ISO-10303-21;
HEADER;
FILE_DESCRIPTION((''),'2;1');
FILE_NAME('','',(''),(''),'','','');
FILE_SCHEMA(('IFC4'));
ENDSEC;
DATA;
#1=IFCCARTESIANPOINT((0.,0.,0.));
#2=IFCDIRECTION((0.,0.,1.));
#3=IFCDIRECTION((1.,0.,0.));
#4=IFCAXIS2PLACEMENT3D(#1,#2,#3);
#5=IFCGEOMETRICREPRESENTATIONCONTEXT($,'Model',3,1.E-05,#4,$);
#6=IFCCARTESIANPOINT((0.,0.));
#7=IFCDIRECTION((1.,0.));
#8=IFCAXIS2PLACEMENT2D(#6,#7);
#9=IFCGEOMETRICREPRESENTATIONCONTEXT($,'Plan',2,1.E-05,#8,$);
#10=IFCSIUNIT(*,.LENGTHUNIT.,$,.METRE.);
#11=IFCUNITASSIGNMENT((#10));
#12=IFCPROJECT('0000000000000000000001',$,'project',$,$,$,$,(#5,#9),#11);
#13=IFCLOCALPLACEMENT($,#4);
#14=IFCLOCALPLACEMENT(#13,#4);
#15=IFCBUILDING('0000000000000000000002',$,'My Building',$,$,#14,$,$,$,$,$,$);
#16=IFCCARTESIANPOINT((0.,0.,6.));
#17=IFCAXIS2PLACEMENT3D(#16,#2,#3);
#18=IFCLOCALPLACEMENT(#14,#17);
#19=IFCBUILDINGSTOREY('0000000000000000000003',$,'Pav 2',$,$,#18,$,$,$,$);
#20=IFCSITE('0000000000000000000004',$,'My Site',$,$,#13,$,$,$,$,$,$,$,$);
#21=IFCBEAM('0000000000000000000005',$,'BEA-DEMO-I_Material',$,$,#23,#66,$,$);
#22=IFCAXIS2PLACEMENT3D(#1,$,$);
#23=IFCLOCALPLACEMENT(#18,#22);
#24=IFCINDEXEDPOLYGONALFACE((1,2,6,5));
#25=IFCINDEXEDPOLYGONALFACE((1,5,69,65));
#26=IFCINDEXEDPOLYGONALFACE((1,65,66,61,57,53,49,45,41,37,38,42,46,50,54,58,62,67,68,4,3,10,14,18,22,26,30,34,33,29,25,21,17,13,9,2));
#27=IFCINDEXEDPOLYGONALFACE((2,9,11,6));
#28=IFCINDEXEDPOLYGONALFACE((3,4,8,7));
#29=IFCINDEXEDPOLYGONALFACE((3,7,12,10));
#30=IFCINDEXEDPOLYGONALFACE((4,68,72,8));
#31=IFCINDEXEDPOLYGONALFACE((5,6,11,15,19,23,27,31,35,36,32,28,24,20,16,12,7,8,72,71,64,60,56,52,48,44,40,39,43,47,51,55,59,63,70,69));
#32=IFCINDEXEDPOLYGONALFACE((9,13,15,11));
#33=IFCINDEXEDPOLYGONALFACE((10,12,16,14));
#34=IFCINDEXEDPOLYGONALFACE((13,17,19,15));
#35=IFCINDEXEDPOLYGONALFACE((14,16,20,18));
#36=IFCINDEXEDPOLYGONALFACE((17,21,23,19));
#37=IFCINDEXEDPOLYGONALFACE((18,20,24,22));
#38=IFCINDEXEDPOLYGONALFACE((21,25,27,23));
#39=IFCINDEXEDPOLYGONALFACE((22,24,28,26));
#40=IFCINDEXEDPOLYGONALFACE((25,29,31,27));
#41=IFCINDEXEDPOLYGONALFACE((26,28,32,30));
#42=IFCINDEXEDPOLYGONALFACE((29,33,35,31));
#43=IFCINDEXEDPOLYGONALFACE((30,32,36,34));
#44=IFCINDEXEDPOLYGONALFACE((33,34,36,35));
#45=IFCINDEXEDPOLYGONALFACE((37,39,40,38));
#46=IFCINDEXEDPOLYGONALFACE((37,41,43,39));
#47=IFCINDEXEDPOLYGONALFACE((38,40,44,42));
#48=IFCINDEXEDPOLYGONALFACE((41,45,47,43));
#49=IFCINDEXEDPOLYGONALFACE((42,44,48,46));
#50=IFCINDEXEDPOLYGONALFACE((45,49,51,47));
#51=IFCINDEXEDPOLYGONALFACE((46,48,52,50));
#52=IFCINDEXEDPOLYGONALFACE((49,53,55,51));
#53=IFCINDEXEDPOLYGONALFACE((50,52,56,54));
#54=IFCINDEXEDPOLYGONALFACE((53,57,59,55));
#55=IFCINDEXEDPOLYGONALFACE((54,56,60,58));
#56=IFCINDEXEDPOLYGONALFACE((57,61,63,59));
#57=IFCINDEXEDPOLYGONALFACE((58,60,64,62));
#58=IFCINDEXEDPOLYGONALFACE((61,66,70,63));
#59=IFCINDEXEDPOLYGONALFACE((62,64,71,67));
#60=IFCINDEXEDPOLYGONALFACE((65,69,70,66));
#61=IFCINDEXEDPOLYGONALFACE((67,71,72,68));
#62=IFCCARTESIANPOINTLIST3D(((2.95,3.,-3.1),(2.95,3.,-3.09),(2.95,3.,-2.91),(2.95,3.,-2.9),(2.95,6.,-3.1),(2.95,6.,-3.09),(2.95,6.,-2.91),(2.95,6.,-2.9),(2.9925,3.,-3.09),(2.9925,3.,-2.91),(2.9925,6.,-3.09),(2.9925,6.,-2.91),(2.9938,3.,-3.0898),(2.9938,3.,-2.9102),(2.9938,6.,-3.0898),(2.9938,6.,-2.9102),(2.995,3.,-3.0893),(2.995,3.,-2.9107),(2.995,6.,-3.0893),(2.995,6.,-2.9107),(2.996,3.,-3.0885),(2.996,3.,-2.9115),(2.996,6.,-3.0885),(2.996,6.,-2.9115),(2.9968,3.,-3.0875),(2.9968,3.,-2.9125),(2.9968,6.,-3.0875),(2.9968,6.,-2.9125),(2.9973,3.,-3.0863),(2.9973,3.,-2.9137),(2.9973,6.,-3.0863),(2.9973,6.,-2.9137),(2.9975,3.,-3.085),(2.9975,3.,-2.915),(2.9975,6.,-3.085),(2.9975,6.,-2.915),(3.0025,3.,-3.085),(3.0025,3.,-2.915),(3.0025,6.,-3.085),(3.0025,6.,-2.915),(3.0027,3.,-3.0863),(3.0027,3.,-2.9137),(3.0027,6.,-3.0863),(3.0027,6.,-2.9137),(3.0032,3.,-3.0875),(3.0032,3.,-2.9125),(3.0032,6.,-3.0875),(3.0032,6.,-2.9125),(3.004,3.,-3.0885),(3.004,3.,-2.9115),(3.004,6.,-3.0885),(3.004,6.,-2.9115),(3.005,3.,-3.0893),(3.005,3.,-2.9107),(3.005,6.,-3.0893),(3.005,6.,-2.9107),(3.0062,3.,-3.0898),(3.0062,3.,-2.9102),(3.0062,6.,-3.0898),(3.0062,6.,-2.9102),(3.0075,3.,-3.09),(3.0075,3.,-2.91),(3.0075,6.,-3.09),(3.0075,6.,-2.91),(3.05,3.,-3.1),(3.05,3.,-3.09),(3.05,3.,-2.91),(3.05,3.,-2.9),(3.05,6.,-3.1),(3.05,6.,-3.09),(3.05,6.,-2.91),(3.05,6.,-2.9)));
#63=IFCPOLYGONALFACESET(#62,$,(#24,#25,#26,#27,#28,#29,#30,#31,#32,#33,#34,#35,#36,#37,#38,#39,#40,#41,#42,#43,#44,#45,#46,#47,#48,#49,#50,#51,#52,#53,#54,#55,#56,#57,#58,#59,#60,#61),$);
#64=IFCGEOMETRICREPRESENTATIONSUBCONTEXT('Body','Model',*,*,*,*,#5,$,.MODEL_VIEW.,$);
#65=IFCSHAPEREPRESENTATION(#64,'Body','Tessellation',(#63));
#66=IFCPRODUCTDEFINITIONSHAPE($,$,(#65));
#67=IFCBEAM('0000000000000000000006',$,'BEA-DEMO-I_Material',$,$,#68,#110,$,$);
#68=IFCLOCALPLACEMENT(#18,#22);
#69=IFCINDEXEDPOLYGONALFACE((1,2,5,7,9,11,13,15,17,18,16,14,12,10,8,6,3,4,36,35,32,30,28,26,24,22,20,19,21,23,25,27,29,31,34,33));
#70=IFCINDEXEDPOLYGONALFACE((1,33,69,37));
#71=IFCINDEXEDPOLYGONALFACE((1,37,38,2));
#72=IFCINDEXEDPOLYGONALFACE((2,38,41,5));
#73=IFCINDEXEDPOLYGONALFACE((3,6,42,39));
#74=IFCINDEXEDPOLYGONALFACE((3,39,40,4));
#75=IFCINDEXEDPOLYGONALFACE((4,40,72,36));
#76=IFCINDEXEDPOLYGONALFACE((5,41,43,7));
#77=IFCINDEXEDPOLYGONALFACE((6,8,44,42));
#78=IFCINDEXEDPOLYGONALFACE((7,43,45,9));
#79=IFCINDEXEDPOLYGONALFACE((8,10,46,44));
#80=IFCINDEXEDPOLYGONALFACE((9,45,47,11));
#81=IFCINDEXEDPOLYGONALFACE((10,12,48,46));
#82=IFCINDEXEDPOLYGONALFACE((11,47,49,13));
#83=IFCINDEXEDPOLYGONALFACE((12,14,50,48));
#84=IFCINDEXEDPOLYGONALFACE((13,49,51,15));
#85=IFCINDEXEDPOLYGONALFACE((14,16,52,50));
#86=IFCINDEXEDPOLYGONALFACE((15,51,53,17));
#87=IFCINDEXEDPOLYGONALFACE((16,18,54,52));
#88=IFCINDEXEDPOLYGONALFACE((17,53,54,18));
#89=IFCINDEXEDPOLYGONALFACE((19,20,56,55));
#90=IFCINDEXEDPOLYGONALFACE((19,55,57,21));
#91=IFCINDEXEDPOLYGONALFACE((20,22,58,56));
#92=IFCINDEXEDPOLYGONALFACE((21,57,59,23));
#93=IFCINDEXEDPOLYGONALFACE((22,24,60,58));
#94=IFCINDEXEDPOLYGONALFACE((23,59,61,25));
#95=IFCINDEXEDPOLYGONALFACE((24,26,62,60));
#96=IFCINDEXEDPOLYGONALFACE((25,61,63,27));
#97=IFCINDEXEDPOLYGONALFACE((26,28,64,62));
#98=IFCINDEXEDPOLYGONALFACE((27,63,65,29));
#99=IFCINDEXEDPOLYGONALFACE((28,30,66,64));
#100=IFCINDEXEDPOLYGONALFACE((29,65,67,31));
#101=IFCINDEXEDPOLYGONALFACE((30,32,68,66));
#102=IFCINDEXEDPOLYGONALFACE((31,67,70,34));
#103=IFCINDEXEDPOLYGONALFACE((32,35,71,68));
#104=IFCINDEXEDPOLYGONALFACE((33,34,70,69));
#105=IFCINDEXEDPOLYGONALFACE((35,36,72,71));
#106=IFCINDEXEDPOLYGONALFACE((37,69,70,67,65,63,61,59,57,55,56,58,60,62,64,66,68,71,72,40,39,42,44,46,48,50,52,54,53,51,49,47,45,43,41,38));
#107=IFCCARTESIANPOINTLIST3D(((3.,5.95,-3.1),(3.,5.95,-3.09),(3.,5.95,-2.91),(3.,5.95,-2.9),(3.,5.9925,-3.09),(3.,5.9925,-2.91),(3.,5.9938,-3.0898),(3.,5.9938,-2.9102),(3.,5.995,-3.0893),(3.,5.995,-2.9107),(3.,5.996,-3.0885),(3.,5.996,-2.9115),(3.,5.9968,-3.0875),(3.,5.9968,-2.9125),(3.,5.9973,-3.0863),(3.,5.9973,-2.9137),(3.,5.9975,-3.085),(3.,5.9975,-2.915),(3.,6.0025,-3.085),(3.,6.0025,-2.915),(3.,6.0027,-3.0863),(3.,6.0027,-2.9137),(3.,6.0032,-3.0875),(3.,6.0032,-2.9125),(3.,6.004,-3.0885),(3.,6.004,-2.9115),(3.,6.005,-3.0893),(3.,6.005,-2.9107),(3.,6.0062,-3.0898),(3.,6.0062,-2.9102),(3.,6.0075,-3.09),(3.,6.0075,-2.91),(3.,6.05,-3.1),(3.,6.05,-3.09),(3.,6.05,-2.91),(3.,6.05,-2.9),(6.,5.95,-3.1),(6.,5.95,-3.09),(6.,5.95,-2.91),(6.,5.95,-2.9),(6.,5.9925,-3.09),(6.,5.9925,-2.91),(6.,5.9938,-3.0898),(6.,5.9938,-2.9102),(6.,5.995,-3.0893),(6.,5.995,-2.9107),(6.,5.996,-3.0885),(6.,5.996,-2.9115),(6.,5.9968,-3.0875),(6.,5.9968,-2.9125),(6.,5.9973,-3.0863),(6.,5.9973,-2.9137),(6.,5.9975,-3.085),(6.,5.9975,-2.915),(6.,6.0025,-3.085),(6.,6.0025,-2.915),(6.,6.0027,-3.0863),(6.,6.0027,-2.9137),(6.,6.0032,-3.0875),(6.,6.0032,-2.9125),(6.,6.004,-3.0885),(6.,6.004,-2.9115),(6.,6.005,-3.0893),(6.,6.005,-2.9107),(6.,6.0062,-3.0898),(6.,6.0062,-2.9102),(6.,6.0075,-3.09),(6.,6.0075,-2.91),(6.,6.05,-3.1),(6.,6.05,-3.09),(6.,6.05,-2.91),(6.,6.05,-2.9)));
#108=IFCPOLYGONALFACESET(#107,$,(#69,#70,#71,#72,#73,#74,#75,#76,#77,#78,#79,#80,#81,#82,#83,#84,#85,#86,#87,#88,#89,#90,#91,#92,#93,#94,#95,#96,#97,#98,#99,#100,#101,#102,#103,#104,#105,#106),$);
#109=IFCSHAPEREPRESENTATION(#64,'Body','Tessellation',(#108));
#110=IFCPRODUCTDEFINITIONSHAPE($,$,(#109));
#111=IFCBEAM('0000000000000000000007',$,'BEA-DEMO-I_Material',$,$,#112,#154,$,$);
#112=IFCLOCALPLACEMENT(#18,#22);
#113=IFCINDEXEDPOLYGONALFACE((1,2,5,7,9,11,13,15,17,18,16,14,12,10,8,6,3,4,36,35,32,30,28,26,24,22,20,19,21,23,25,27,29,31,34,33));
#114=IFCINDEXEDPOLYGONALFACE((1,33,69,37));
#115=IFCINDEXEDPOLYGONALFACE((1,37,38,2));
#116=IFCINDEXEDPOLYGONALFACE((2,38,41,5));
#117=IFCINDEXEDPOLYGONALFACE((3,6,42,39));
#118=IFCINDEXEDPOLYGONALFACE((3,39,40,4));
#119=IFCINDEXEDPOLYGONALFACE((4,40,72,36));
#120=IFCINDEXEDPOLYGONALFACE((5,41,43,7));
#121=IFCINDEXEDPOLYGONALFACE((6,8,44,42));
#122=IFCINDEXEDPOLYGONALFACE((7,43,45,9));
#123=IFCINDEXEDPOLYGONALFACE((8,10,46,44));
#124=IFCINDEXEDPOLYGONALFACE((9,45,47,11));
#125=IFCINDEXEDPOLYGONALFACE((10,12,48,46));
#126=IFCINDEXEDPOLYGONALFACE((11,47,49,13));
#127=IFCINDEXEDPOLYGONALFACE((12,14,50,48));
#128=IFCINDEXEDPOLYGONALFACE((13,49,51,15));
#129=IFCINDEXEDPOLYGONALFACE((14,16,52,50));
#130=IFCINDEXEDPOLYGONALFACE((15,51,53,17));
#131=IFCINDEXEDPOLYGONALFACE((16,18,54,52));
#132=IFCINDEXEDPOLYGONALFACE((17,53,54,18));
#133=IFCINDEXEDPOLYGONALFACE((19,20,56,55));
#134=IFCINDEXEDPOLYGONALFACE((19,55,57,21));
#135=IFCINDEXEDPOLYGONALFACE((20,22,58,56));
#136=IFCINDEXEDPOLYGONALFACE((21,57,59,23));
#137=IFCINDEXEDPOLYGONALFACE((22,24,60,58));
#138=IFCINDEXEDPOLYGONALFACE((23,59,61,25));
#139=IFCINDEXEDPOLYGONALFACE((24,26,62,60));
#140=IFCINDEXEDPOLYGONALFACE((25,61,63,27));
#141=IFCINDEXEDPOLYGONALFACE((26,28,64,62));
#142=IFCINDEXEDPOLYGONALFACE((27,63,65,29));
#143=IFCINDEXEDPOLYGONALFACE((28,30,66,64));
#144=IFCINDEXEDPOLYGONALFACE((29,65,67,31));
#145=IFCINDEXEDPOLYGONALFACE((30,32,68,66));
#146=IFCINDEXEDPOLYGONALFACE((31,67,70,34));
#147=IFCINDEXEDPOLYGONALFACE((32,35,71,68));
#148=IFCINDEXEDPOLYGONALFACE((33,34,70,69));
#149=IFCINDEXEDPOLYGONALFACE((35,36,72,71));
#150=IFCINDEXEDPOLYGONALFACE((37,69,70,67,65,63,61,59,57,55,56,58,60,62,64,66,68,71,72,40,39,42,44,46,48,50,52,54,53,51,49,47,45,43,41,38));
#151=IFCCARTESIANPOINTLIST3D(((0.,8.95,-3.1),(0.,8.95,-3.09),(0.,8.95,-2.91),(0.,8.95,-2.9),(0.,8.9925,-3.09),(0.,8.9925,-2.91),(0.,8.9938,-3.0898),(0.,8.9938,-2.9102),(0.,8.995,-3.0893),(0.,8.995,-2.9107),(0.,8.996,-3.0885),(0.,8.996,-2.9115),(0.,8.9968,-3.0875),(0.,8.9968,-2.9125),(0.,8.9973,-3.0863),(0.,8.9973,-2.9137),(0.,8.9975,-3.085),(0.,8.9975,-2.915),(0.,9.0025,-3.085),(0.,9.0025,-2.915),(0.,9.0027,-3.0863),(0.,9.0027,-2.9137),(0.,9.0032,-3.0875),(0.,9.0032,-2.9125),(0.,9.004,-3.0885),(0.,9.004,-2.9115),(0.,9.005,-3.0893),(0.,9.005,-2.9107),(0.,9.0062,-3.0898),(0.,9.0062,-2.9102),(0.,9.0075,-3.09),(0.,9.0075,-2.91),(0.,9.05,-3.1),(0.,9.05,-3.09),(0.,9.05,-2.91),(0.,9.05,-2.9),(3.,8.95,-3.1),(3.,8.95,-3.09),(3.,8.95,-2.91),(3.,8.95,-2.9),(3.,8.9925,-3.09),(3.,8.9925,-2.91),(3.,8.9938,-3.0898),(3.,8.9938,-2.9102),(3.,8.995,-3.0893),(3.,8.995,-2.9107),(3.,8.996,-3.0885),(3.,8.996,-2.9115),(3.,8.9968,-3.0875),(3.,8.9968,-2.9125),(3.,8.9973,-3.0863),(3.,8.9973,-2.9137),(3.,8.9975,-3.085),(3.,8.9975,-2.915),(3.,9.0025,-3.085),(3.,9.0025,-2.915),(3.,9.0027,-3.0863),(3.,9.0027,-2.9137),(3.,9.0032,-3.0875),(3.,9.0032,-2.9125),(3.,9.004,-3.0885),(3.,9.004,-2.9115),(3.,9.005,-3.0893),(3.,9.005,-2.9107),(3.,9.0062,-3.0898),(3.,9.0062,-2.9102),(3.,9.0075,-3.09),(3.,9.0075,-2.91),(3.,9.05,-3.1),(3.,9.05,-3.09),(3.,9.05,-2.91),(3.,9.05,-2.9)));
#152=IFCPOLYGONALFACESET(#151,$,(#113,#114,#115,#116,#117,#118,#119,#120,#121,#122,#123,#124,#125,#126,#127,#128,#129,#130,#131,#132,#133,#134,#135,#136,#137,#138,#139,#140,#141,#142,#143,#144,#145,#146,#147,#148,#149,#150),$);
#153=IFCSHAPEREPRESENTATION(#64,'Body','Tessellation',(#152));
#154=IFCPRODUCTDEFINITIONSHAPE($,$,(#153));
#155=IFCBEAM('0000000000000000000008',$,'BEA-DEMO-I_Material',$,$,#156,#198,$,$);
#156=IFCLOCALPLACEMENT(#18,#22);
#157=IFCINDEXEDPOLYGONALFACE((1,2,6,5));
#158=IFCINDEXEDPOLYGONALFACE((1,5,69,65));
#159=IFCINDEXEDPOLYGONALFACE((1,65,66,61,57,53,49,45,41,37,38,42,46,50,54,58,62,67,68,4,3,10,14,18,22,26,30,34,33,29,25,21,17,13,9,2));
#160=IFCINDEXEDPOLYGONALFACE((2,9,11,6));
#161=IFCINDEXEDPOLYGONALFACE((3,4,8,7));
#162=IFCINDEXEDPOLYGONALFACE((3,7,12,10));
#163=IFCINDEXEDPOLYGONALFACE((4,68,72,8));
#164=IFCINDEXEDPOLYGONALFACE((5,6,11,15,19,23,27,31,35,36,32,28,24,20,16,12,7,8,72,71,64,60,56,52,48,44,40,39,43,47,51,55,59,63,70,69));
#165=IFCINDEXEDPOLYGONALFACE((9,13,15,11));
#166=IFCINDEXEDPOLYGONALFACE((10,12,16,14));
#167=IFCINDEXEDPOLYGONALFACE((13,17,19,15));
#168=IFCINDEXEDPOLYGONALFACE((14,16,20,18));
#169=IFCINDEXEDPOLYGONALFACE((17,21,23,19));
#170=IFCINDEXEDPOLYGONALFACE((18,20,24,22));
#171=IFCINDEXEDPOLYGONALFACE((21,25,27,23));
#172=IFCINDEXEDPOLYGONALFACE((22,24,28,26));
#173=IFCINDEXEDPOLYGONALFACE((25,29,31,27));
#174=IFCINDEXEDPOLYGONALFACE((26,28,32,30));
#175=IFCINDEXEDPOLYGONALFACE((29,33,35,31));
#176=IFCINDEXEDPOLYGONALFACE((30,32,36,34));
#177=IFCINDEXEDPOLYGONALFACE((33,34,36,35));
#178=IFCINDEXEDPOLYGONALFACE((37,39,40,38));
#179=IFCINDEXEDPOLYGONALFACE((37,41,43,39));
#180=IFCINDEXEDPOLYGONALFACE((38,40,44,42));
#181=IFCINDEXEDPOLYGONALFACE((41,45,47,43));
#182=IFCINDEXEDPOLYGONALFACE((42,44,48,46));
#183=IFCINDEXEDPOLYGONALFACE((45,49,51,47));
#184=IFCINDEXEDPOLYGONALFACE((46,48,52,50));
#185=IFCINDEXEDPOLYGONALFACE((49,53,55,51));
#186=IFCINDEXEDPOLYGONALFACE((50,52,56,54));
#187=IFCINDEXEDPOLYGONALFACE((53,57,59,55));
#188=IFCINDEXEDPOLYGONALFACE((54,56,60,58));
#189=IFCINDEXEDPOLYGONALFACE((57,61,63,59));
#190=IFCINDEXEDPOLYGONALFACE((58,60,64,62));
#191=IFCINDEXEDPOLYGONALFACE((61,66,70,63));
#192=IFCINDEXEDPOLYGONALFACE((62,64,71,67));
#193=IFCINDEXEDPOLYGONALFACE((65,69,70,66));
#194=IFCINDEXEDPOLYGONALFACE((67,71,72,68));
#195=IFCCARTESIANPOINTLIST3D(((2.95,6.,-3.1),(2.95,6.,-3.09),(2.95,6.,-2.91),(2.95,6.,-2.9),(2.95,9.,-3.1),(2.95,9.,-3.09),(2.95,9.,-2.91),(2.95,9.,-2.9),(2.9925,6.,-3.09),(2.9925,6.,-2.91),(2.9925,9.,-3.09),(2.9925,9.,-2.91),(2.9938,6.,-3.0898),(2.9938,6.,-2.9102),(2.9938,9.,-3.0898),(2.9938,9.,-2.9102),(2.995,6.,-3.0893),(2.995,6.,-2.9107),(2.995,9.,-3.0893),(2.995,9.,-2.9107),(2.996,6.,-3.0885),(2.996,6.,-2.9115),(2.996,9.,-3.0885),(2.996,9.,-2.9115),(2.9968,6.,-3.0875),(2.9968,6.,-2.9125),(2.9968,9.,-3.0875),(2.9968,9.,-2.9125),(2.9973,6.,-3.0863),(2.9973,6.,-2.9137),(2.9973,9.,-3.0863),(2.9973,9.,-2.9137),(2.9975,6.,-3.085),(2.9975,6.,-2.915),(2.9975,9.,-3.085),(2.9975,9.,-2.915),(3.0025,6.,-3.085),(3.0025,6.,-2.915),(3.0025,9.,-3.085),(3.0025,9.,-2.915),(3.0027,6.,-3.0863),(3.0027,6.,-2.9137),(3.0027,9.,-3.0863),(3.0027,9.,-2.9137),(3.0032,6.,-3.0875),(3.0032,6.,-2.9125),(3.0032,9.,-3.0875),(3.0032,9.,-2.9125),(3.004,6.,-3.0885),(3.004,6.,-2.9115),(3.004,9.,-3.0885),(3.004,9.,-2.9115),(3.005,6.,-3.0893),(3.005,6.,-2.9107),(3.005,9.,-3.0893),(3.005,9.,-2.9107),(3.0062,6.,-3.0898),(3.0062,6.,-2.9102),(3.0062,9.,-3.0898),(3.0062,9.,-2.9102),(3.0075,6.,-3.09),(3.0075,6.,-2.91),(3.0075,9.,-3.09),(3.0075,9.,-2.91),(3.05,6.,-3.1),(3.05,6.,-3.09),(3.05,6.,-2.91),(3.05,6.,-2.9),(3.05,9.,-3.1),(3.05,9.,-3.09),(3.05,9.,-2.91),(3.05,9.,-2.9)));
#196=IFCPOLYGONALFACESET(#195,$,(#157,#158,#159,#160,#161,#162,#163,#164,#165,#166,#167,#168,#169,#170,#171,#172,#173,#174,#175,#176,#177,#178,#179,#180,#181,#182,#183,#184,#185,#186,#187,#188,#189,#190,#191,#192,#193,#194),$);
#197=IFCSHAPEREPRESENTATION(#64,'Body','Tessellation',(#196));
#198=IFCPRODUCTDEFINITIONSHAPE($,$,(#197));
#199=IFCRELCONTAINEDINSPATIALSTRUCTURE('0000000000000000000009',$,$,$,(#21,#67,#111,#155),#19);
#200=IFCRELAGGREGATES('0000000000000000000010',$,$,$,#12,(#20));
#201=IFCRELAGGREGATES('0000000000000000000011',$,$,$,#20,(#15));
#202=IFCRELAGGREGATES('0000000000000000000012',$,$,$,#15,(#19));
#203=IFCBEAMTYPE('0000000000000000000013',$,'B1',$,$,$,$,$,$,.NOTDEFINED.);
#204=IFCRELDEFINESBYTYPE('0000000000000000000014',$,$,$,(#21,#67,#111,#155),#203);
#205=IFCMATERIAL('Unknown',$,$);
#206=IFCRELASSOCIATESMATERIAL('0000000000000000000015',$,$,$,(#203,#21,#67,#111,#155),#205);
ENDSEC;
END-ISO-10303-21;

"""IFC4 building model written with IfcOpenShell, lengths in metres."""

from ifc_helpers import new_model, si_unit, frame, origin, origin_with_axes, origin_2d_with_axis, place, context, subcontext, project, spatial, i_section, extrude, material, material_profile, profile_set, profile_usage, type_object, element, save


model = new_model("IFC4")

# Units and contexts
model_context = context("Model", 3, precision=1e-05, world=origin_with_axes())
plan_context = context("Plan", 2, precision=1e-05, world=origin_2d_with_axis())
body_context = subcontext(model_context, "Body", "Model", "MODEL_VIEW")
ifc_project = project(units=[si_unit("LENGTHUNIT", "METRE")], contexts=[model_context, plan_context])

# Site, building, storey
site_placement = place(None, origin_with_axes())
site = spatial("IfcSite", under=ifc_project, at=site_placement, Name="My Site")
building_placement = place(site_placement, origin_with_axes())
building = spatial("IfcBuilding", under=site, at=building_placement, Name="My Building")
storey_placement = place(building_placement, frame((0.0, 0.0, 6.0), z_axis=(0.0, 0.0, 1.0), x_axis=(1.0, 0.0, 0.0)))
storey = spatial("IfcBuildingStorey", under=building, at=storey_placement, Name="Pav 2")

# Beams
ifc_material = material(Name="Unknown")
ifc_material_profile = material_profile(ifc_material, i_section(OverallWidth=0.1, OverallDepth=0.2, WebThickness=0.005, FlangeThickness=0.01, FilletRadius=0.005))
ifc_profile_set = profile_set([ifc_material_profile])
ifc_profile_usage_1 = profile_usage(ifc_profile_set, cardinal=5)
beam_type = type_object("IfcBeamType", Name="B1", PredefinedType="NOTDEFINED", material=ifc_profile_set)
beam_1_placement = place(storey_placement, frame((3.0, 6.0, -3.0), z_axis=(0.0, -1.0, 0.0), x_axis=(1.0, 0.0, 0.0)))
element("IfcBeam", 1, at=beam_1_placement, inside=storey, type_object=beam_type, material=ifc_profile_usage_1, Name="BEA-DEMO-I_Material", context=body_context, shape_type="SweptSolid", body=[
    extrude(i_section(OverallWidth=0.1, OverallDepth=0.2, WebThickness=0.005, FlangeThickness=0.01, FilletRadius=0.005), origin(), (0.0, 0.0, 1.0), 3.0),
])
ifc_profile_usage_2 = profile_usage(ifc_profile_set, cardinal=5)
beam_2_placement = place(storey_placement, frame((3.0, 6.0, -3.0), z_axis=(1.0, 0.0, 0.0), x_axis=(0.0, 1.0, 0.0)))
element("IfcBeam", 2, at=beam_2_placement, inside=storey, type_object=beam_type, material=ifc_profile_usage_2, Name="BEA-DEMO-I_Material", context=body_context, shape_type="SweptSolid", body=[
    extrude(i_section(OverallWidth=0.1, OverallDepth=0.2, WebThickness=0.005, FlangeThickness=0.01, FilletRadius=0.005), origin(), (0.0, 0.0, 1.0), 3.0),
])
ifc_profile_usage_3 = profile_usage(ifc_profile_set, cardinal=5)
beam_3_placement = place(storey_placement, frame((0.0, 9.0, -3.0), z_axis=(1.0, 0.0, 0.0), x_axis=(0.0, 1.0, 0.0)))
element("IfcBeam", 3, at=beam_3_placement, inside=storey, type_object=beam_type, material=ifc_profile_usage_3, Name="BEA-DEMO-I_Material", context=body_context, shape_type="SweptSolid", body=[
    extrude(i_section(OverallWidth=0.1, OverallDepth=0.2, WebThickness=0.005, FlangeThickness=0.01, FilletRadius=0.005), origin(), (0.0, 0.0, 1.0), 3.0),
])
ifc_profile_usage_4 = profile_usage(ifc_profile_set, cardinal=5)
beam_4_placement = place(storey_placement, frame((3.0, 9.0, -3.0), z_axis=(0.0, -1.0, 0.0), x_axis=(1.0, 0.0, 0.0)))
element("IfcBeam", 4, at=beam_4_placement, inside=storey, type_object=beam_type, material=ifc_profile_usage_4, Name="BEA-DEMO-I_Material", context=body_context, shape_type="SweptSolid", body=[
    extrude(i_section(OverallWidth=0.1, OverallDepth=0.2, WebThickness=0.005, FlangeThickness=0.01, FilletRadius=0.005), origin(), (0.0, 0.0, 1.0), 3.0),
])

save(model, "model.ifc")
